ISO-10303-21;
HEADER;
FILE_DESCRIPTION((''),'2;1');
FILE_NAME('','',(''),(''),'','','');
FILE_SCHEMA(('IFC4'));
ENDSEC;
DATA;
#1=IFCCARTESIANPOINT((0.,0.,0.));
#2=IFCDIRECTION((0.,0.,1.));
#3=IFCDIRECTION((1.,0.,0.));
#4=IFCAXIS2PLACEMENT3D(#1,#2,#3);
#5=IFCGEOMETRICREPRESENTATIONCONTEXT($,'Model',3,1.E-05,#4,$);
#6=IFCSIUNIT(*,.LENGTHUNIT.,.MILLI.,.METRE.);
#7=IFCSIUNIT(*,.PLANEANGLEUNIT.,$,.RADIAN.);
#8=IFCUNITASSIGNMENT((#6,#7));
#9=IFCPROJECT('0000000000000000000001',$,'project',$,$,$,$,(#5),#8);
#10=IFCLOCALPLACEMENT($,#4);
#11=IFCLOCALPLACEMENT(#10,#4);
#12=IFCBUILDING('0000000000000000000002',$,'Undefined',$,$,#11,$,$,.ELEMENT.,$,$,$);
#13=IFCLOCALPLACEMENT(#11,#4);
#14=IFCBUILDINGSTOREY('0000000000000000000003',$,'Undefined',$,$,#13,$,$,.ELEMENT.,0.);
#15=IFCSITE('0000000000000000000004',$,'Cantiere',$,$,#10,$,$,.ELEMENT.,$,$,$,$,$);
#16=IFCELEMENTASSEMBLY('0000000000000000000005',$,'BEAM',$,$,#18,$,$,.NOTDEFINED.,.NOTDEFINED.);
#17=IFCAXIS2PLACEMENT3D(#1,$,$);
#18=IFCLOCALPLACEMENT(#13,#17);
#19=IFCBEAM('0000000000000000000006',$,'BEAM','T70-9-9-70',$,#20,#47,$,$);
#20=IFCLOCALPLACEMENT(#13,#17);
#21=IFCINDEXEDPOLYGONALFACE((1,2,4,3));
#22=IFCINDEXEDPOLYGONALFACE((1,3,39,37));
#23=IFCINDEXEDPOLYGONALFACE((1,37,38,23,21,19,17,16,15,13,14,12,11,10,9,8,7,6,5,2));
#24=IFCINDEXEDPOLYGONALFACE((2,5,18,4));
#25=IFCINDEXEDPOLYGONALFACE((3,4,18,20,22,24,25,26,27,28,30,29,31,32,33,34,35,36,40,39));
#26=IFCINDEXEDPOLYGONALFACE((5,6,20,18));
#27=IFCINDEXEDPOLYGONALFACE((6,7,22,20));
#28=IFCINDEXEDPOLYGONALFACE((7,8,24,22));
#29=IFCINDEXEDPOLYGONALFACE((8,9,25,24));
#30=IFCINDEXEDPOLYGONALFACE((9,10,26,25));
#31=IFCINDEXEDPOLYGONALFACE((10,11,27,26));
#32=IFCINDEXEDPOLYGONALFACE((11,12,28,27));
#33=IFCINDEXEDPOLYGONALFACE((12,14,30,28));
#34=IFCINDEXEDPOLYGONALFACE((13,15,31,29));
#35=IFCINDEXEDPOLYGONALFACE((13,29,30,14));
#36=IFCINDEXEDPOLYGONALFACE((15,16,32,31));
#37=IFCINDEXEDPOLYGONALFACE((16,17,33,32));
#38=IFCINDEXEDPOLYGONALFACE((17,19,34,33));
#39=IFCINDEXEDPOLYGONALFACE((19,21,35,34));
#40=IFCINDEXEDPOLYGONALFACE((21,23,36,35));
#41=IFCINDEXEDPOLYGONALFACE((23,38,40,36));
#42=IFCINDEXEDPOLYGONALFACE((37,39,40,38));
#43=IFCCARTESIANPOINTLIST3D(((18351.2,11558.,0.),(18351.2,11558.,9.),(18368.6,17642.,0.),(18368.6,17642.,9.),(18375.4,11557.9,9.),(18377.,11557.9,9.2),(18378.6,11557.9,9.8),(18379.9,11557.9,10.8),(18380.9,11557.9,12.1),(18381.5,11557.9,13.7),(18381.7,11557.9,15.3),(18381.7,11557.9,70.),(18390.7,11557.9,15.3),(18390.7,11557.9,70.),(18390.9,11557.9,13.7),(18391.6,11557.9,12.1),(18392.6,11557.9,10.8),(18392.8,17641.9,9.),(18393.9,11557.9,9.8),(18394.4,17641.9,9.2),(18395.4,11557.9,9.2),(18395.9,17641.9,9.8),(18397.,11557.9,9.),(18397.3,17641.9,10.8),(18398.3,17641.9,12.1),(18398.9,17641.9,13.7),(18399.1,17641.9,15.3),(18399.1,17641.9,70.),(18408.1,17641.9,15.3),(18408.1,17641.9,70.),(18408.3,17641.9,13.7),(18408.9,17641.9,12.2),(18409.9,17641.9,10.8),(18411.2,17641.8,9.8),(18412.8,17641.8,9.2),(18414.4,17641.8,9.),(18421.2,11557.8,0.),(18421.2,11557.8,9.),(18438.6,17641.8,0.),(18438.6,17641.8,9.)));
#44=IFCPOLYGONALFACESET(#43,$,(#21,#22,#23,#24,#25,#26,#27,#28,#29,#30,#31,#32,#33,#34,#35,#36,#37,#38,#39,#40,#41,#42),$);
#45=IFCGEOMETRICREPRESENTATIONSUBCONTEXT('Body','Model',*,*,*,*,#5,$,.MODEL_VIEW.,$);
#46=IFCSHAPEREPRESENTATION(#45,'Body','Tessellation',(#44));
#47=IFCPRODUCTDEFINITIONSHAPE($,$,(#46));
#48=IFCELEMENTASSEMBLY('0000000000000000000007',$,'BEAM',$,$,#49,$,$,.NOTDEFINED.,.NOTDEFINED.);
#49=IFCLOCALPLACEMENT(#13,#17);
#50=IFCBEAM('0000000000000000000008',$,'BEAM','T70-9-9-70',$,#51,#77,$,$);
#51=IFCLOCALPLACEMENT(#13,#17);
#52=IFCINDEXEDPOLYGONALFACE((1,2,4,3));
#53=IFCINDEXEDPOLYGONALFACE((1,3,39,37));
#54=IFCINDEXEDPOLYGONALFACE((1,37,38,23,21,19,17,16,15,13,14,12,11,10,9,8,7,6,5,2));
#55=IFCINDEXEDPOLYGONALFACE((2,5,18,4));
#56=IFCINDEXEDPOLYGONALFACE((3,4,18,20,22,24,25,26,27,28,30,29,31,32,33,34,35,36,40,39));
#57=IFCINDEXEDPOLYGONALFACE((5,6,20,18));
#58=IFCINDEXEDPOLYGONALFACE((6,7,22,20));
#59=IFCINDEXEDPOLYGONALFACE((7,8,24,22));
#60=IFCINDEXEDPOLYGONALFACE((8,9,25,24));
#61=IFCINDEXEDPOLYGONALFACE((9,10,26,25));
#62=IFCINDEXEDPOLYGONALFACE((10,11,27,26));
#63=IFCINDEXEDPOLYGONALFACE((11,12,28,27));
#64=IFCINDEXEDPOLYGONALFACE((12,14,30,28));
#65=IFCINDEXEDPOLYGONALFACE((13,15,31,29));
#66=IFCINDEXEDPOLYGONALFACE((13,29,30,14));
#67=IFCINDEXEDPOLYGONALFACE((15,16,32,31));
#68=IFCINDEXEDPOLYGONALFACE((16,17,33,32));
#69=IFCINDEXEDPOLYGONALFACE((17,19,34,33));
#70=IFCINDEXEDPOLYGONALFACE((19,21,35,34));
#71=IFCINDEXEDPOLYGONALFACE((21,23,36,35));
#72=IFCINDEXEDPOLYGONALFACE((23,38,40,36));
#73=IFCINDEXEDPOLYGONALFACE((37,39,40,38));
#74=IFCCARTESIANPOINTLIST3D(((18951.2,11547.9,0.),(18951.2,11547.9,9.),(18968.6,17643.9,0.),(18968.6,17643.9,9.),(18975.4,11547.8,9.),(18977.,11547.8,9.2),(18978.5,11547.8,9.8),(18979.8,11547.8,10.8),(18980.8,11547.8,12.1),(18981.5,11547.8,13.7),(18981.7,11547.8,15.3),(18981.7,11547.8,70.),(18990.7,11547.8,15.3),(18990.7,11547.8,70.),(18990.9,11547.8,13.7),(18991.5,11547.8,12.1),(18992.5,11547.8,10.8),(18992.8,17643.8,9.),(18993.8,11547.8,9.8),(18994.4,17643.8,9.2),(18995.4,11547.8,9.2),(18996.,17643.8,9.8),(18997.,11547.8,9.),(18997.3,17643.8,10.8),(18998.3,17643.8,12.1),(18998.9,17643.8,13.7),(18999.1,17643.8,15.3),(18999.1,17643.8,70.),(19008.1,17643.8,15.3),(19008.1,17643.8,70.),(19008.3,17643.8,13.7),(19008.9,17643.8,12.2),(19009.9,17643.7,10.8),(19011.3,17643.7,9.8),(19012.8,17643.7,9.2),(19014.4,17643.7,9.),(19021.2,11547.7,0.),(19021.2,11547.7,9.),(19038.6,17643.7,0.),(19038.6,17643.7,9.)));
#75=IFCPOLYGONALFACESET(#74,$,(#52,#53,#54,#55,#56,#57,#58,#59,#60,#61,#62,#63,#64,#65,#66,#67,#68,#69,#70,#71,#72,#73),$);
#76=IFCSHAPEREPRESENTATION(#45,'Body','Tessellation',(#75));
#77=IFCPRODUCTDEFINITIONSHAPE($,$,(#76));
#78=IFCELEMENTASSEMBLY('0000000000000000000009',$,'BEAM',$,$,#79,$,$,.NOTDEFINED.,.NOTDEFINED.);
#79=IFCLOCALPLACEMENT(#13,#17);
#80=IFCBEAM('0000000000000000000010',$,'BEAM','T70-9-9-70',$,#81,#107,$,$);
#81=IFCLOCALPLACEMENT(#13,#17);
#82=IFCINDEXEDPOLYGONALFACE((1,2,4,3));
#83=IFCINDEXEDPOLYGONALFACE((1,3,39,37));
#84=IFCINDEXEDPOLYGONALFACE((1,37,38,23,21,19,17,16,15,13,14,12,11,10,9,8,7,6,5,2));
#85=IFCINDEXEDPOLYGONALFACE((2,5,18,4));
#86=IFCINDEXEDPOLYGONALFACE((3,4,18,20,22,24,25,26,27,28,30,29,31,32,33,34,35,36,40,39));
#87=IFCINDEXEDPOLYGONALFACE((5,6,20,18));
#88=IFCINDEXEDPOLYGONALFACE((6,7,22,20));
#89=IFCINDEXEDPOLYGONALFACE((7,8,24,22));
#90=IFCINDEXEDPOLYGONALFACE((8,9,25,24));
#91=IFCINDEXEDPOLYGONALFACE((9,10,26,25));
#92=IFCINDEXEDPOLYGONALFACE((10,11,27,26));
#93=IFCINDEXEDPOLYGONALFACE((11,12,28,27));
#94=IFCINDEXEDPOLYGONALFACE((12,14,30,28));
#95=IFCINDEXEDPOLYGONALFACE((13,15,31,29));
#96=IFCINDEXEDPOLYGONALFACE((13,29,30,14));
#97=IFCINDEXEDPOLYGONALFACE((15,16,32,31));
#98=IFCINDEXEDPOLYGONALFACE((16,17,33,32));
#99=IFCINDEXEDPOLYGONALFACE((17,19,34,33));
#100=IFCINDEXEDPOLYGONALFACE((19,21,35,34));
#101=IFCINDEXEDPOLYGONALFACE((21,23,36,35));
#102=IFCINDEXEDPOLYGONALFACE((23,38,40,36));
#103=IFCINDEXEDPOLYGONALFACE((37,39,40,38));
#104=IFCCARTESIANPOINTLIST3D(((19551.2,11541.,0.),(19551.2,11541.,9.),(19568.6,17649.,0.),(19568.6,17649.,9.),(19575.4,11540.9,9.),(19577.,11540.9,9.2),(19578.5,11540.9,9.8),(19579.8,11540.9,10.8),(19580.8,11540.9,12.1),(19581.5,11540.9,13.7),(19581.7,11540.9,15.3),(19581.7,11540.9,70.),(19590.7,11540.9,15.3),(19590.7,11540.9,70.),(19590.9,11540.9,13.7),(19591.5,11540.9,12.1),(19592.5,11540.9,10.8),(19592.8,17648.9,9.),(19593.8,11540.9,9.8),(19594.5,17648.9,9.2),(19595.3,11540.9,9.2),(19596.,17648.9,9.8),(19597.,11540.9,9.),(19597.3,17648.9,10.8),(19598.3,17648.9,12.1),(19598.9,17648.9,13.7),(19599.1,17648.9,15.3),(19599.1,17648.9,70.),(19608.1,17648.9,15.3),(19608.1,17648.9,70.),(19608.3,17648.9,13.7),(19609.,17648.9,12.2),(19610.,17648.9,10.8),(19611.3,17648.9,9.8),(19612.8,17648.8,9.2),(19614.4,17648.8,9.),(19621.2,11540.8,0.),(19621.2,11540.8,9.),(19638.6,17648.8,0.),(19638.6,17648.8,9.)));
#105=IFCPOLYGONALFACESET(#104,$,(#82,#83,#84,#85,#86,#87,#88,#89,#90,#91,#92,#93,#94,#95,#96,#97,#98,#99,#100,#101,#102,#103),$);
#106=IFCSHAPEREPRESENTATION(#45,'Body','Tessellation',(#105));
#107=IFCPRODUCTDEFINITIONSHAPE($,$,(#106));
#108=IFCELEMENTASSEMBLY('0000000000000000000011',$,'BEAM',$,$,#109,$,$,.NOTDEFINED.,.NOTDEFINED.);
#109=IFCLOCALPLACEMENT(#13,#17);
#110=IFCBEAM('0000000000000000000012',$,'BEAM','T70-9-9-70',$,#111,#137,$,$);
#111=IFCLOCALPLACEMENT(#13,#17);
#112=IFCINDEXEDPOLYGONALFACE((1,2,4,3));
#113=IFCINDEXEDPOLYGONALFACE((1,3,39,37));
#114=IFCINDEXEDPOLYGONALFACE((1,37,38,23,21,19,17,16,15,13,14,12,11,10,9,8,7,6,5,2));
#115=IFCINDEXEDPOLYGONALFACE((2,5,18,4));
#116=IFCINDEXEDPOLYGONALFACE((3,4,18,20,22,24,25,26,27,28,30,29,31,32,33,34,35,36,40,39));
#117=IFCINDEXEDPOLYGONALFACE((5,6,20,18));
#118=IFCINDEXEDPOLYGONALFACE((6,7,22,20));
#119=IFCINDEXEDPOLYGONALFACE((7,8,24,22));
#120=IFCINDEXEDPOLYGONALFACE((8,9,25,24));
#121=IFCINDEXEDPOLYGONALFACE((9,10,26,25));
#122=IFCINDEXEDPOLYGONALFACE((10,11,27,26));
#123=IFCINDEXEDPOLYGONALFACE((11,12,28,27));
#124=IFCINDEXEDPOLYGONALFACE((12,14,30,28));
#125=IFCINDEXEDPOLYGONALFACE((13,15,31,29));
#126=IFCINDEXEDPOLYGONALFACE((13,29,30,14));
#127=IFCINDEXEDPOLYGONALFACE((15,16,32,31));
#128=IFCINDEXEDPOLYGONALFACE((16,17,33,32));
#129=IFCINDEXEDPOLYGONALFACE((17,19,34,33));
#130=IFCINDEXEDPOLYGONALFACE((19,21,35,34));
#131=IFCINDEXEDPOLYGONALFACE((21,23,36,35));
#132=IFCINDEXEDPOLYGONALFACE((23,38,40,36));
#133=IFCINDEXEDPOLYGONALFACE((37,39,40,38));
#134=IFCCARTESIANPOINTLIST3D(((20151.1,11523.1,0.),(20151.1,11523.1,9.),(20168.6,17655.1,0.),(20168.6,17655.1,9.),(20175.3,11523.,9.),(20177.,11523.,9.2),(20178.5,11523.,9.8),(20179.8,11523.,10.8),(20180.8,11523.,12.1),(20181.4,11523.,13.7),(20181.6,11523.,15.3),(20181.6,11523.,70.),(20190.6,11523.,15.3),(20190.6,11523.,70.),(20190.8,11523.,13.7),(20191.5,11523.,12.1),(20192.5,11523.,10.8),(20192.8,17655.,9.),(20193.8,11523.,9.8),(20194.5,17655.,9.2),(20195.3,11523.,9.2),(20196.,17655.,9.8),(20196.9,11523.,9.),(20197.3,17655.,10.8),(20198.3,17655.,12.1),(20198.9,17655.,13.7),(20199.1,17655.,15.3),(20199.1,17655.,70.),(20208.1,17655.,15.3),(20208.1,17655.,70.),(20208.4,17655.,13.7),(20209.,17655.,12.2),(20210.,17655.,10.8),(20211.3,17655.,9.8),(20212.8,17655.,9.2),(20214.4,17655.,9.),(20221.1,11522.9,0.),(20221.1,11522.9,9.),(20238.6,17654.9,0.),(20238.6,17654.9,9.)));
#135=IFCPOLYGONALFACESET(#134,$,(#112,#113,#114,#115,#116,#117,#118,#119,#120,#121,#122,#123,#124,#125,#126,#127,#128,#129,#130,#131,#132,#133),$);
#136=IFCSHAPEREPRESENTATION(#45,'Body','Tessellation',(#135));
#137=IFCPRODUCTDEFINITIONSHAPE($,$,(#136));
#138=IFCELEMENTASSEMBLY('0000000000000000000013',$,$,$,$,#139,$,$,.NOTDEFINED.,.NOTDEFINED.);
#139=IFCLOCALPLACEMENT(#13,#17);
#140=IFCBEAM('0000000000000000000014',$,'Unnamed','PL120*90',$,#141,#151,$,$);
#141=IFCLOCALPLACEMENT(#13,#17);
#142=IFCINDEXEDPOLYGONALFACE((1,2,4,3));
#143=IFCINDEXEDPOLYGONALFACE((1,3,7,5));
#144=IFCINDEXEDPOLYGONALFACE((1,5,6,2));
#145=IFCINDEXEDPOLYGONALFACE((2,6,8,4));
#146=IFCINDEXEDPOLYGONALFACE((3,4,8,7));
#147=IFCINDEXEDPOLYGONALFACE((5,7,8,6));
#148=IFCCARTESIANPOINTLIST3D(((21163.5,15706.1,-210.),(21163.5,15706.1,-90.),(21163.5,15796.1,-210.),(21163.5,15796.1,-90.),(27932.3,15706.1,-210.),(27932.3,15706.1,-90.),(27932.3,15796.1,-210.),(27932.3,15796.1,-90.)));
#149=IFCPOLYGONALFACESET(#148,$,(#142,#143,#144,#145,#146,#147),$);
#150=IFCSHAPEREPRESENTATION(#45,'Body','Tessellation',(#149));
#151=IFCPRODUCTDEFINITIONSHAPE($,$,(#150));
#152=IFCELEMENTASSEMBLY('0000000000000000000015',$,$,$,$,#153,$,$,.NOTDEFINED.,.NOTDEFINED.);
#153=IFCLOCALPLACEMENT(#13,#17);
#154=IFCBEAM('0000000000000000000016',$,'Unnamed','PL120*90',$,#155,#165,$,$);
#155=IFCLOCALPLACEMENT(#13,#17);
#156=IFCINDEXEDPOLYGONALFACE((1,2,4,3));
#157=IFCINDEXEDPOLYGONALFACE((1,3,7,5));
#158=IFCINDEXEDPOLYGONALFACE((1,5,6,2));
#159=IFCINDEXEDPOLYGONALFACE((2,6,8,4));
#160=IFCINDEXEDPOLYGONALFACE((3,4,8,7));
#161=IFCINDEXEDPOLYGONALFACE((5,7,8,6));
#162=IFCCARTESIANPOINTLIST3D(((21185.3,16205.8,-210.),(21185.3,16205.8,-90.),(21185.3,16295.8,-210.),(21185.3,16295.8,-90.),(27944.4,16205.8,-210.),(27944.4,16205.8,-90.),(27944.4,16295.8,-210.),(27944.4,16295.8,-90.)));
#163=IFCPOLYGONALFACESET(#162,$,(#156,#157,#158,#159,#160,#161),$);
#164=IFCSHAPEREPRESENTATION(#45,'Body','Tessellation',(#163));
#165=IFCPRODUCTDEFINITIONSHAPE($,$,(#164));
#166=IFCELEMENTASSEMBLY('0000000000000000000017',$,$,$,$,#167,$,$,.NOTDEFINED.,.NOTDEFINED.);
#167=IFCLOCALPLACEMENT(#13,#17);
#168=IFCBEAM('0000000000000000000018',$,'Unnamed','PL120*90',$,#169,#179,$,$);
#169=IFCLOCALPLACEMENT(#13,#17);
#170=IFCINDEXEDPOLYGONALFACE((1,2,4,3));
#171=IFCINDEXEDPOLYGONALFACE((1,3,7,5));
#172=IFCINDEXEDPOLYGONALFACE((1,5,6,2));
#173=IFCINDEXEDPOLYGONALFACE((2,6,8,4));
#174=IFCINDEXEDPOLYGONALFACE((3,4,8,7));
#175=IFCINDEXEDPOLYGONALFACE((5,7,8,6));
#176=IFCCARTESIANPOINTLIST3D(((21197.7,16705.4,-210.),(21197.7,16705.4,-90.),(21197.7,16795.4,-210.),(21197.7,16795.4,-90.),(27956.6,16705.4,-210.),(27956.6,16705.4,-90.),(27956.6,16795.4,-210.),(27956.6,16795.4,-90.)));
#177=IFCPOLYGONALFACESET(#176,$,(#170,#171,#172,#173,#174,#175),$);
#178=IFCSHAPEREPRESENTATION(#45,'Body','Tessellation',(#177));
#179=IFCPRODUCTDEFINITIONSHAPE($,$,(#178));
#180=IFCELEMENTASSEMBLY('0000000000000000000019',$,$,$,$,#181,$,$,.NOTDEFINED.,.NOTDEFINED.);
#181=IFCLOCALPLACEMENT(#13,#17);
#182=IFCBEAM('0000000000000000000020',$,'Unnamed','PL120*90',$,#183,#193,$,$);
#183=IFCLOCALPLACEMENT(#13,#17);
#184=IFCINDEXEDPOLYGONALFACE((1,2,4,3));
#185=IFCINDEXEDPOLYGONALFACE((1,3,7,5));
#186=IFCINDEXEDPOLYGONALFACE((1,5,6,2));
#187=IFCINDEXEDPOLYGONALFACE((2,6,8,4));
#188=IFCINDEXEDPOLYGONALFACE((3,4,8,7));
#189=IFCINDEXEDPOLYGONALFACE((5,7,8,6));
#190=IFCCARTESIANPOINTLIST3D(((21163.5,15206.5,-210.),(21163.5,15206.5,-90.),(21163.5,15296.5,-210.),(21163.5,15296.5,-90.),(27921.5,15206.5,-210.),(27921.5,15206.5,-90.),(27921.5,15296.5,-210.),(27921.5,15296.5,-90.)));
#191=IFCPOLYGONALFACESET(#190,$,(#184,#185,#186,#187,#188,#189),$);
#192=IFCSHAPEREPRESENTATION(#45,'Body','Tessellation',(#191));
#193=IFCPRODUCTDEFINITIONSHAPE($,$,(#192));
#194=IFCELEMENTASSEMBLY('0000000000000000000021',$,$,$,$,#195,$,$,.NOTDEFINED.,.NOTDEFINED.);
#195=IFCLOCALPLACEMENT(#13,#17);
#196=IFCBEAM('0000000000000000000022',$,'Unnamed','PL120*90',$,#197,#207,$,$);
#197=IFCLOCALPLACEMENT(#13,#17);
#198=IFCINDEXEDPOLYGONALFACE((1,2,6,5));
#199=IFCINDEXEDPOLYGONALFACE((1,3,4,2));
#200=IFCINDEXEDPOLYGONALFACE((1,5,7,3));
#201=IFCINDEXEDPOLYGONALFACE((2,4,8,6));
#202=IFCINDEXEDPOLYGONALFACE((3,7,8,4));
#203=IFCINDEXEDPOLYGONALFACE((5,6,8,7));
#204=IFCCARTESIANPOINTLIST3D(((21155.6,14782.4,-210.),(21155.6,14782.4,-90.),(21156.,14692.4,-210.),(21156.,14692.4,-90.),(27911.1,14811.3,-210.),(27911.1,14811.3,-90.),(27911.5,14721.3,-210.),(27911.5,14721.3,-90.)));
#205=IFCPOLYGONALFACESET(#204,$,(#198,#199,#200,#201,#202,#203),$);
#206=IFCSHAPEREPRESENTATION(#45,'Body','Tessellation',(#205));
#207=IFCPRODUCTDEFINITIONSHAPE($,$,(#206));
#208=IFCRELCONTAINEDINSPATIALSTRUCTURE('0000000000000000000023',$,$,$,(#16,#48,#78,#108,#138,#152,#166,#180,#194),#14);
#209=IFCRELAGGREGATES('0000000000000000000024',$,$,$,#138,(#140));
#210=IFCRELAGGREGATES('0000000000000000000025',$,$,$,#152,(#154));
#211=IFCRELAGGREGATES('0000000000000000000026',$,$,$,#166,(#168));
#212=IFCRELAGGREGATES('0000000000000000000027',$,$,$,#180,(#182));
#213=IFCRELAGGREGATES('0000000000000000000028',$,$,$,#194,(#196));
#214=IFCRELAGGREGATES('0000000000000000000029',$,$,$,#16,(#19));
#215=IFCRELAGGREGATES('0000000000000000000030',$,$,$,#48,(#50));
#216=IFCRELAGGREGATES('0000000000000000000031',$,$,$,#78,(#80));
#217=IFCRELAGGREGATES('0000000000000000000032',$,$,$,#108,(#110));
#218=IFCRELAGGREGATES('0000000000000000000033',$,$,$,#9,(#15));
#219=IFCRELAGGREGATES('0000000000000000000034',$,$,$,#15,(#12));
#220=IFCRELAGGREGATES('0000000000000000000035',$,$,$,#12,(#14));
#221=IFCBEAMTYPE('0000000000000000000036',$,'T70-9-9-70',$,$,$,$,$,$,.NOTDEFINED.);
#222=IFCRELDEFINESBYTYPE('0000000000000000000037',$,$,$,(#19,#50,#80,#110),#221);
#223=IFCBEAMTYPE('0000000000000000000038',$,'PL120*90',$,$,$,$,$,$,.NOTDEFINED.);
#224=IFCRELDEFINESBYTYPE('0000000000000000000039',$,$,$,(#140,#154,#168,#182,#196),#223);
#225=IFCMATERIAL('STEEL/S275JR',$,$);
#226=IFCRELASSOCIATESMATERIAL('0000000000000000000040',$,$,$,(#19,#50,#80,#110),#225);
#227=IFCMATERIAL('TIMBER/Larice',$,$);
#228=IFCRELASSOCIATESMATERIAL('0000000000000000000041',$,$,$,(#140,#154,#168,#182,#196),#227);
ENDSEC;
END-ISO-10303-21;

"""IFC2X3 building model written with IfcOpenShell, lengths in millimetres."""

from ifc_helpers import new_model, si_unit, frame, origin_with_axes, origin_2d_with_axis, place, context, subcontext, project, spatial, rectangle, t_section, extrude, material, type_object, element, aggregate, save


model = new_model("IFC2X3")

# Units and contexts
model_context = context("Model", 3, precision=1e-05, world=origin_with_axes())
body_context = subcontext(model_context, "Body", "Model", "MODEL_VIEW")
ifc_project = project(units=[si_unit("LENGTHUNIT", "METRE", prefix="MILLI"), si_unit("PLANEANGLEUNIT", "RADIAN")], contexts=[model_context])

# Site, building, storey
site_placement = place(None, origin_with_axes())
site = spatial("IfcSite", under=ifc_project, at=site_placement, Name="Cantiere", CompositionType="ELEMENT")
building_placement = place(site_placement, origin_with_axes())
building = spatial("IfcBuilding", under=site, at=building_placement, Name="Undefined", CompositionType="ELEMENT")
storey_placement = place(building_placement, origin_with_axes())
storey = spatial("IfcBuildingStorey", under=building, at=storey_placement, Name="Undefined", CompositionType="ELEMENT", Elevation=0.0)

# Element assemblies, beams
assembly_1_placement = place(storey_placement, origin_with_axes())
assembly_1 = element("IfcElementAssembly", 1, at=assembly_1_placement, inside=storey, Name="BEAM", AssemblyPlace="NOTDEFINED", PredefinedType="NOTDEFINED")
ifc_material_1 = material(Name="STEEL/S275JR")
beam_type_1 = type_object("IfcBeamType", Name="T70-9-9-70", PredefinedType="NOTDEFINED")
beam_1_placement = place(assembly_1_placement, frame((18403.6, 17641.9, 35.0), z_axis=(0.0, 0.000001, -1.0), x_axis=(-0.002857, -0.999996, 0.0)))
beam_1 = element("IfcBeam", 2, at=beam_1_placement, type_object=beam_type_1, material=ifc_material_1, Name="BEAM", Description="T70-9-9-70", context=body_context, shape_type="SweptSolid", body=[
    extrude(t_section(Depth=70.0, FlangeWidth=70.0, WebThickness=9.0, FlangeThickness=9.0, FilletRadius=6.3, at=origin_2d_with_axis()), frame((6084.0, 0.0, 0.0), z_axis=(-1.0, 0.0, 0.0), x_axis=(0.0, -1.0, 0.0)), (0.0, 0.0, 1.0), 6084.0),
])
assembly_2_placement = place(storey_placement, origin_with_axes())
assembly_2 = element("IfcElementAssembly", 3, at=assembly_2_placement, inside=storey, Name="BEAM", AssemblyPlace="NOTDEFINED", PredefinedType="NOTDEFINED")
beam_2_placement = place(assembly_2_placement, frame((19003.6, 17643.8, 35.0), z_axis=(0.0, 0.000001, -1.0), x_axis=(-0.002857, -0.999996, 0.0)))
beam_2 = element("IfcBeam", 4, at=beam_2_placement, type_object=beam_type_1, material=ifc_material_1, Name="BEAM", Description="T70-9-9-70", context=body_context, shape_type="SweptSolid", body=[
    extrude(t_section(Depth=70.0, FlangeWidth=70.0, WebThickness=9.0, FlangeThickness=9.0, FilletRadius=6.3, at=origin_2d_with_axis()), frame((6096.0, 0.0, 0.0), z_axis=(-1.0, 0.0, 0.0), x_axis=(0.0, -1.0, 0.0)), (0.0, 0.0, 1.0), 6096.0),
])
assembly_3_placement = place(storey_placement, origin_with_axes())
assembly_3 = element("IfcElementAssembly", 5, at=assembly_3_placement, inside=storey, Name="BEAM", AssemblyPlace="NOTDEFINED", PredefinedType="NOTDEFINED")
beam_3_placement = place(assembly_3_placement, frame((19603.6, 17648.9, 35.0), z_axis=(0.0, 0.000001, -1.0), x_axis=(-0.002857, -0.999996, 0.0)))
beam_3 = element("IfcBeam", 6, at=beam_3_placement, type_object=beam_type_1, material=ifc_material_1, Name="BEAM", Description="T70-9-9-70", context=body_context, shape_type="SweptSolid", body=[
    extrude(t_section(Depth=70.0, FlangeWidth=70.0, WebThickness=9.0, FlangeThickness=9.0, FilletRadius=6.3, at=origin_2d_with_axis()), frame((6108.0, 0.0, 0.0), z_axis=(-1.0, 0.0, 0.0), x_axis=(0.0, -1.0, 0.0)), (0.0, 0.0, 1.0), 6108.0),
])
assembly_4_placement = place(storey_placement, origin_with_axes())
assembly_4 = element("IfcElementAssembly", 7, at=assembly_4_placement, inside=storey, Name="BEAM", AssemblyPlace="NOTDEFINED", PredefinedType="NOTDEFINED")
beam_4_placement = place(assembly_4_placement, frame((20203.6, 17655.0, 35.0), z_axis=(0.0, 0.000001, -1.0), x_axis=(-0.002857, -0.999996, 0.0)))
beam_4 = element("IfcBeam", 8, at=beam_4_placement, type_object=beam_type_1, material=ifc_material_1, Name="BEAM", Description="T70-9-9-70", context=body_context, shape_type="SweptSolid", body=[
    extrude(t_section(Depth=70.0, FlangeWidth=70.0, WebThickness=9.0, FlangeThickness=9.0, FilletRadius=6.3, at=origin_2d_with_axis()), frame((6132.0, 0.0, 0.0), z_axis=(-1.0, 0.0, 0.0), x_axis=(0.0, -1.0, 0.0)), (0.0, 0.0, 1.0), 6132.0),
])
assembly_5_placement = place(storey_placement, origin_with_axes())
assembly_5 = element("IfcElementAssembly", 9, at=assembly_5_placement, inside=storey, AssemblyPlace="NOTDEFINED", PredefinedType="NOTDEFINED")
ifc_material_2 = material(Name="TIMBER/Larice")
beam_type_2 = type_object("IfcBeamType", Name="PL120*90", PredefinedType="NOTDEFINED")
beam_5_placement = place(assembly_5_placement, frame((21163.5, 15751.1, -150.0), z_axis=(0.0, 0.0, 1.0), x_axis=(1.0, 0.0, 0.0)))
beam_5 = element("IfcBeam", 10, at=beam_5_placement, type_object=beam_type_2, material=ifc_material_2, Name="Unnamed", Description="PL120*90", context=body_context, shape_type="SweptSolid", body=[
    extrude(rectangle(XDim=90.0, YDim=120.0, at=origin_2d_with_axis()), frame((6768.8, 0.0, 0.0), z_axis=(-1.0, 0.0, 0.0), x_axis=(0.0, -1.0, 0.0)), (0.0, 0.0, 1.0), 6768.8),
])
aggregate(assembly_5, [beam_5])
assembly_6_placement = place(storey_placement, origin_with_axes())
assembly_6 = element("IfcElementAssembly", 11, at=assembly_6_placement, inside=storey, AssemblyPlace="NOTDEFINED", PredefinedType="NOTDEFINED")
beam_6_placement = place(assembly_6_placement, frame((21185.3, 16250.8, -150.0), z_axis=(0.0, 0.0, 1.0), x_axis=(1.0, 0.0, 0.0)))
beam_6 = element("IfcBeam", 12, at=beam_6_placement, type_object=beam_type_2, material=ifc_material_2, Name="Unnamed", Description="PL120*90", context=body_context, shape_type="SweptSolid", body=[
    extrude(rectangle(XDim=90.0, YDim=120.0, at=origin_2d_with_axis()), frame((6759.1, 0.0, 0.0), z_axis=(-1.0, 0.0, 0.0), x_axis=(0.0, -1.0, 0.0)), (0.0, 0.0, 1.0), 6759.1),
])
aggregate(assembly_6, [beam_6])
assembly_7_placement = place(storey_placement, origin_with_axes())
assembly_7 = element("IfcElementAssembly", 13, at=assembly_7_placement, inside=storey, AssemblyPlace="NOTDEFINED", PredefinedType="NOTDEFINED")
beam_7_placement = place(assembly_7_placement, frame((21197.7, 16750.4, -150.0), z_axis=(0.0, 0.0, 1.0), x_axis=(1.0, 0.0, 0.0)))
beam_7 = element("IfcBeam", 14, at=beam_7_placement, type_object=beam_type_2, material=ifc_material_2, Name="Unnamed", Description="PL120*90", context=body_context, shape_type="SweptSolid", body=[
    extrude(rectangle(XDim=90.0, YDim=120.0, at=origin_2d_with_axis()), frame((6758.9, 0.0, 0.0), z_axis=(-1.0, 0.0, 0.0), x_axis=(0.0, -1.0, 0.0)), (0.0, 0.0, 1.0), 6758.9),
])
aggregate(assembly_7, [beam_7])
assembly_8_placement = place(storey_placement, origin_with_axes())
assembly_8 = element("IfcElementAssembly", 15, at=assembly_8_placement, inside=storey, AssemblyPlace="NOTDEFINED", PredefinedType="NOTDEFINED")
beam_8_placement = place(assembly_8_placement, frame((21163.5, 15251.5, -150.0), z_axis=(0.0, 0.0, 1.0), x_axis=(1.0, 0.0, 0.0)))
beam_8 = element("IfcBeam", 16, at=beam_8_placement, type_object=beam_type_2, material=ifc_material_2, Name="Unnamed", Description="PL120*90", context=body_context, shape_type="SweptSolid", body=[
    extrude(rectangle(XDim=90.0, YDim=120.0, at=origin_2d_with_axis()), frame((6758.0, 0.0, 0.0), z_axis=(-1.0, 0.0, 0.0), x_axis=(0.0, -1.0, 0.0)), (0.0, 0.0, 1.0), 6757.9),
])
aggregate(assembly_8, [beam_8])
assembly_9_placement = place(storey_placement, origin_with_axes())
assembly_9 = element("IfcElementAssembly", 17, at=assembly_9_placement, inside=storey, AssemblyPlace="NOTDEFINED", PredefinedType="NOTDEFINED")
beam_9_placement = place(assembly_9_placement, frame((21155.8, 14737.4, -150.0), z_axis=(0.0, 0.0, 1.0), x_axis=(0.999991, 0.004283, 0.0)))
beam_9 = element("IfcBeam", 18, at=beam_9_placement, type_object=beam_type_2, material=ifc_material_2, Name="Unnamed", Description="PL120*90", context=body_context, shape_type="SweptSolid", body=[
    extrude(rectangle(XDim=90.0, YDim=120.0, at=origin_2d_with_axis()), frame((6755.6, 0.0, 0.0), z_axis=(-1.0, 0.0, 0.0), x_axis=(0.0, -1.0, 0.0)), (0.0, 0.0, 1.0), 6755.6),
])
aggregate(assembly_9, [beam_9])

aggregate(assembly_1, [beam_1])
aggregate(assembly_2, [beam_2])
aggregate(assembly_3, [beam_3])
aggregate(assembly_4, [beam_4])

save(model, "model.ifc")
